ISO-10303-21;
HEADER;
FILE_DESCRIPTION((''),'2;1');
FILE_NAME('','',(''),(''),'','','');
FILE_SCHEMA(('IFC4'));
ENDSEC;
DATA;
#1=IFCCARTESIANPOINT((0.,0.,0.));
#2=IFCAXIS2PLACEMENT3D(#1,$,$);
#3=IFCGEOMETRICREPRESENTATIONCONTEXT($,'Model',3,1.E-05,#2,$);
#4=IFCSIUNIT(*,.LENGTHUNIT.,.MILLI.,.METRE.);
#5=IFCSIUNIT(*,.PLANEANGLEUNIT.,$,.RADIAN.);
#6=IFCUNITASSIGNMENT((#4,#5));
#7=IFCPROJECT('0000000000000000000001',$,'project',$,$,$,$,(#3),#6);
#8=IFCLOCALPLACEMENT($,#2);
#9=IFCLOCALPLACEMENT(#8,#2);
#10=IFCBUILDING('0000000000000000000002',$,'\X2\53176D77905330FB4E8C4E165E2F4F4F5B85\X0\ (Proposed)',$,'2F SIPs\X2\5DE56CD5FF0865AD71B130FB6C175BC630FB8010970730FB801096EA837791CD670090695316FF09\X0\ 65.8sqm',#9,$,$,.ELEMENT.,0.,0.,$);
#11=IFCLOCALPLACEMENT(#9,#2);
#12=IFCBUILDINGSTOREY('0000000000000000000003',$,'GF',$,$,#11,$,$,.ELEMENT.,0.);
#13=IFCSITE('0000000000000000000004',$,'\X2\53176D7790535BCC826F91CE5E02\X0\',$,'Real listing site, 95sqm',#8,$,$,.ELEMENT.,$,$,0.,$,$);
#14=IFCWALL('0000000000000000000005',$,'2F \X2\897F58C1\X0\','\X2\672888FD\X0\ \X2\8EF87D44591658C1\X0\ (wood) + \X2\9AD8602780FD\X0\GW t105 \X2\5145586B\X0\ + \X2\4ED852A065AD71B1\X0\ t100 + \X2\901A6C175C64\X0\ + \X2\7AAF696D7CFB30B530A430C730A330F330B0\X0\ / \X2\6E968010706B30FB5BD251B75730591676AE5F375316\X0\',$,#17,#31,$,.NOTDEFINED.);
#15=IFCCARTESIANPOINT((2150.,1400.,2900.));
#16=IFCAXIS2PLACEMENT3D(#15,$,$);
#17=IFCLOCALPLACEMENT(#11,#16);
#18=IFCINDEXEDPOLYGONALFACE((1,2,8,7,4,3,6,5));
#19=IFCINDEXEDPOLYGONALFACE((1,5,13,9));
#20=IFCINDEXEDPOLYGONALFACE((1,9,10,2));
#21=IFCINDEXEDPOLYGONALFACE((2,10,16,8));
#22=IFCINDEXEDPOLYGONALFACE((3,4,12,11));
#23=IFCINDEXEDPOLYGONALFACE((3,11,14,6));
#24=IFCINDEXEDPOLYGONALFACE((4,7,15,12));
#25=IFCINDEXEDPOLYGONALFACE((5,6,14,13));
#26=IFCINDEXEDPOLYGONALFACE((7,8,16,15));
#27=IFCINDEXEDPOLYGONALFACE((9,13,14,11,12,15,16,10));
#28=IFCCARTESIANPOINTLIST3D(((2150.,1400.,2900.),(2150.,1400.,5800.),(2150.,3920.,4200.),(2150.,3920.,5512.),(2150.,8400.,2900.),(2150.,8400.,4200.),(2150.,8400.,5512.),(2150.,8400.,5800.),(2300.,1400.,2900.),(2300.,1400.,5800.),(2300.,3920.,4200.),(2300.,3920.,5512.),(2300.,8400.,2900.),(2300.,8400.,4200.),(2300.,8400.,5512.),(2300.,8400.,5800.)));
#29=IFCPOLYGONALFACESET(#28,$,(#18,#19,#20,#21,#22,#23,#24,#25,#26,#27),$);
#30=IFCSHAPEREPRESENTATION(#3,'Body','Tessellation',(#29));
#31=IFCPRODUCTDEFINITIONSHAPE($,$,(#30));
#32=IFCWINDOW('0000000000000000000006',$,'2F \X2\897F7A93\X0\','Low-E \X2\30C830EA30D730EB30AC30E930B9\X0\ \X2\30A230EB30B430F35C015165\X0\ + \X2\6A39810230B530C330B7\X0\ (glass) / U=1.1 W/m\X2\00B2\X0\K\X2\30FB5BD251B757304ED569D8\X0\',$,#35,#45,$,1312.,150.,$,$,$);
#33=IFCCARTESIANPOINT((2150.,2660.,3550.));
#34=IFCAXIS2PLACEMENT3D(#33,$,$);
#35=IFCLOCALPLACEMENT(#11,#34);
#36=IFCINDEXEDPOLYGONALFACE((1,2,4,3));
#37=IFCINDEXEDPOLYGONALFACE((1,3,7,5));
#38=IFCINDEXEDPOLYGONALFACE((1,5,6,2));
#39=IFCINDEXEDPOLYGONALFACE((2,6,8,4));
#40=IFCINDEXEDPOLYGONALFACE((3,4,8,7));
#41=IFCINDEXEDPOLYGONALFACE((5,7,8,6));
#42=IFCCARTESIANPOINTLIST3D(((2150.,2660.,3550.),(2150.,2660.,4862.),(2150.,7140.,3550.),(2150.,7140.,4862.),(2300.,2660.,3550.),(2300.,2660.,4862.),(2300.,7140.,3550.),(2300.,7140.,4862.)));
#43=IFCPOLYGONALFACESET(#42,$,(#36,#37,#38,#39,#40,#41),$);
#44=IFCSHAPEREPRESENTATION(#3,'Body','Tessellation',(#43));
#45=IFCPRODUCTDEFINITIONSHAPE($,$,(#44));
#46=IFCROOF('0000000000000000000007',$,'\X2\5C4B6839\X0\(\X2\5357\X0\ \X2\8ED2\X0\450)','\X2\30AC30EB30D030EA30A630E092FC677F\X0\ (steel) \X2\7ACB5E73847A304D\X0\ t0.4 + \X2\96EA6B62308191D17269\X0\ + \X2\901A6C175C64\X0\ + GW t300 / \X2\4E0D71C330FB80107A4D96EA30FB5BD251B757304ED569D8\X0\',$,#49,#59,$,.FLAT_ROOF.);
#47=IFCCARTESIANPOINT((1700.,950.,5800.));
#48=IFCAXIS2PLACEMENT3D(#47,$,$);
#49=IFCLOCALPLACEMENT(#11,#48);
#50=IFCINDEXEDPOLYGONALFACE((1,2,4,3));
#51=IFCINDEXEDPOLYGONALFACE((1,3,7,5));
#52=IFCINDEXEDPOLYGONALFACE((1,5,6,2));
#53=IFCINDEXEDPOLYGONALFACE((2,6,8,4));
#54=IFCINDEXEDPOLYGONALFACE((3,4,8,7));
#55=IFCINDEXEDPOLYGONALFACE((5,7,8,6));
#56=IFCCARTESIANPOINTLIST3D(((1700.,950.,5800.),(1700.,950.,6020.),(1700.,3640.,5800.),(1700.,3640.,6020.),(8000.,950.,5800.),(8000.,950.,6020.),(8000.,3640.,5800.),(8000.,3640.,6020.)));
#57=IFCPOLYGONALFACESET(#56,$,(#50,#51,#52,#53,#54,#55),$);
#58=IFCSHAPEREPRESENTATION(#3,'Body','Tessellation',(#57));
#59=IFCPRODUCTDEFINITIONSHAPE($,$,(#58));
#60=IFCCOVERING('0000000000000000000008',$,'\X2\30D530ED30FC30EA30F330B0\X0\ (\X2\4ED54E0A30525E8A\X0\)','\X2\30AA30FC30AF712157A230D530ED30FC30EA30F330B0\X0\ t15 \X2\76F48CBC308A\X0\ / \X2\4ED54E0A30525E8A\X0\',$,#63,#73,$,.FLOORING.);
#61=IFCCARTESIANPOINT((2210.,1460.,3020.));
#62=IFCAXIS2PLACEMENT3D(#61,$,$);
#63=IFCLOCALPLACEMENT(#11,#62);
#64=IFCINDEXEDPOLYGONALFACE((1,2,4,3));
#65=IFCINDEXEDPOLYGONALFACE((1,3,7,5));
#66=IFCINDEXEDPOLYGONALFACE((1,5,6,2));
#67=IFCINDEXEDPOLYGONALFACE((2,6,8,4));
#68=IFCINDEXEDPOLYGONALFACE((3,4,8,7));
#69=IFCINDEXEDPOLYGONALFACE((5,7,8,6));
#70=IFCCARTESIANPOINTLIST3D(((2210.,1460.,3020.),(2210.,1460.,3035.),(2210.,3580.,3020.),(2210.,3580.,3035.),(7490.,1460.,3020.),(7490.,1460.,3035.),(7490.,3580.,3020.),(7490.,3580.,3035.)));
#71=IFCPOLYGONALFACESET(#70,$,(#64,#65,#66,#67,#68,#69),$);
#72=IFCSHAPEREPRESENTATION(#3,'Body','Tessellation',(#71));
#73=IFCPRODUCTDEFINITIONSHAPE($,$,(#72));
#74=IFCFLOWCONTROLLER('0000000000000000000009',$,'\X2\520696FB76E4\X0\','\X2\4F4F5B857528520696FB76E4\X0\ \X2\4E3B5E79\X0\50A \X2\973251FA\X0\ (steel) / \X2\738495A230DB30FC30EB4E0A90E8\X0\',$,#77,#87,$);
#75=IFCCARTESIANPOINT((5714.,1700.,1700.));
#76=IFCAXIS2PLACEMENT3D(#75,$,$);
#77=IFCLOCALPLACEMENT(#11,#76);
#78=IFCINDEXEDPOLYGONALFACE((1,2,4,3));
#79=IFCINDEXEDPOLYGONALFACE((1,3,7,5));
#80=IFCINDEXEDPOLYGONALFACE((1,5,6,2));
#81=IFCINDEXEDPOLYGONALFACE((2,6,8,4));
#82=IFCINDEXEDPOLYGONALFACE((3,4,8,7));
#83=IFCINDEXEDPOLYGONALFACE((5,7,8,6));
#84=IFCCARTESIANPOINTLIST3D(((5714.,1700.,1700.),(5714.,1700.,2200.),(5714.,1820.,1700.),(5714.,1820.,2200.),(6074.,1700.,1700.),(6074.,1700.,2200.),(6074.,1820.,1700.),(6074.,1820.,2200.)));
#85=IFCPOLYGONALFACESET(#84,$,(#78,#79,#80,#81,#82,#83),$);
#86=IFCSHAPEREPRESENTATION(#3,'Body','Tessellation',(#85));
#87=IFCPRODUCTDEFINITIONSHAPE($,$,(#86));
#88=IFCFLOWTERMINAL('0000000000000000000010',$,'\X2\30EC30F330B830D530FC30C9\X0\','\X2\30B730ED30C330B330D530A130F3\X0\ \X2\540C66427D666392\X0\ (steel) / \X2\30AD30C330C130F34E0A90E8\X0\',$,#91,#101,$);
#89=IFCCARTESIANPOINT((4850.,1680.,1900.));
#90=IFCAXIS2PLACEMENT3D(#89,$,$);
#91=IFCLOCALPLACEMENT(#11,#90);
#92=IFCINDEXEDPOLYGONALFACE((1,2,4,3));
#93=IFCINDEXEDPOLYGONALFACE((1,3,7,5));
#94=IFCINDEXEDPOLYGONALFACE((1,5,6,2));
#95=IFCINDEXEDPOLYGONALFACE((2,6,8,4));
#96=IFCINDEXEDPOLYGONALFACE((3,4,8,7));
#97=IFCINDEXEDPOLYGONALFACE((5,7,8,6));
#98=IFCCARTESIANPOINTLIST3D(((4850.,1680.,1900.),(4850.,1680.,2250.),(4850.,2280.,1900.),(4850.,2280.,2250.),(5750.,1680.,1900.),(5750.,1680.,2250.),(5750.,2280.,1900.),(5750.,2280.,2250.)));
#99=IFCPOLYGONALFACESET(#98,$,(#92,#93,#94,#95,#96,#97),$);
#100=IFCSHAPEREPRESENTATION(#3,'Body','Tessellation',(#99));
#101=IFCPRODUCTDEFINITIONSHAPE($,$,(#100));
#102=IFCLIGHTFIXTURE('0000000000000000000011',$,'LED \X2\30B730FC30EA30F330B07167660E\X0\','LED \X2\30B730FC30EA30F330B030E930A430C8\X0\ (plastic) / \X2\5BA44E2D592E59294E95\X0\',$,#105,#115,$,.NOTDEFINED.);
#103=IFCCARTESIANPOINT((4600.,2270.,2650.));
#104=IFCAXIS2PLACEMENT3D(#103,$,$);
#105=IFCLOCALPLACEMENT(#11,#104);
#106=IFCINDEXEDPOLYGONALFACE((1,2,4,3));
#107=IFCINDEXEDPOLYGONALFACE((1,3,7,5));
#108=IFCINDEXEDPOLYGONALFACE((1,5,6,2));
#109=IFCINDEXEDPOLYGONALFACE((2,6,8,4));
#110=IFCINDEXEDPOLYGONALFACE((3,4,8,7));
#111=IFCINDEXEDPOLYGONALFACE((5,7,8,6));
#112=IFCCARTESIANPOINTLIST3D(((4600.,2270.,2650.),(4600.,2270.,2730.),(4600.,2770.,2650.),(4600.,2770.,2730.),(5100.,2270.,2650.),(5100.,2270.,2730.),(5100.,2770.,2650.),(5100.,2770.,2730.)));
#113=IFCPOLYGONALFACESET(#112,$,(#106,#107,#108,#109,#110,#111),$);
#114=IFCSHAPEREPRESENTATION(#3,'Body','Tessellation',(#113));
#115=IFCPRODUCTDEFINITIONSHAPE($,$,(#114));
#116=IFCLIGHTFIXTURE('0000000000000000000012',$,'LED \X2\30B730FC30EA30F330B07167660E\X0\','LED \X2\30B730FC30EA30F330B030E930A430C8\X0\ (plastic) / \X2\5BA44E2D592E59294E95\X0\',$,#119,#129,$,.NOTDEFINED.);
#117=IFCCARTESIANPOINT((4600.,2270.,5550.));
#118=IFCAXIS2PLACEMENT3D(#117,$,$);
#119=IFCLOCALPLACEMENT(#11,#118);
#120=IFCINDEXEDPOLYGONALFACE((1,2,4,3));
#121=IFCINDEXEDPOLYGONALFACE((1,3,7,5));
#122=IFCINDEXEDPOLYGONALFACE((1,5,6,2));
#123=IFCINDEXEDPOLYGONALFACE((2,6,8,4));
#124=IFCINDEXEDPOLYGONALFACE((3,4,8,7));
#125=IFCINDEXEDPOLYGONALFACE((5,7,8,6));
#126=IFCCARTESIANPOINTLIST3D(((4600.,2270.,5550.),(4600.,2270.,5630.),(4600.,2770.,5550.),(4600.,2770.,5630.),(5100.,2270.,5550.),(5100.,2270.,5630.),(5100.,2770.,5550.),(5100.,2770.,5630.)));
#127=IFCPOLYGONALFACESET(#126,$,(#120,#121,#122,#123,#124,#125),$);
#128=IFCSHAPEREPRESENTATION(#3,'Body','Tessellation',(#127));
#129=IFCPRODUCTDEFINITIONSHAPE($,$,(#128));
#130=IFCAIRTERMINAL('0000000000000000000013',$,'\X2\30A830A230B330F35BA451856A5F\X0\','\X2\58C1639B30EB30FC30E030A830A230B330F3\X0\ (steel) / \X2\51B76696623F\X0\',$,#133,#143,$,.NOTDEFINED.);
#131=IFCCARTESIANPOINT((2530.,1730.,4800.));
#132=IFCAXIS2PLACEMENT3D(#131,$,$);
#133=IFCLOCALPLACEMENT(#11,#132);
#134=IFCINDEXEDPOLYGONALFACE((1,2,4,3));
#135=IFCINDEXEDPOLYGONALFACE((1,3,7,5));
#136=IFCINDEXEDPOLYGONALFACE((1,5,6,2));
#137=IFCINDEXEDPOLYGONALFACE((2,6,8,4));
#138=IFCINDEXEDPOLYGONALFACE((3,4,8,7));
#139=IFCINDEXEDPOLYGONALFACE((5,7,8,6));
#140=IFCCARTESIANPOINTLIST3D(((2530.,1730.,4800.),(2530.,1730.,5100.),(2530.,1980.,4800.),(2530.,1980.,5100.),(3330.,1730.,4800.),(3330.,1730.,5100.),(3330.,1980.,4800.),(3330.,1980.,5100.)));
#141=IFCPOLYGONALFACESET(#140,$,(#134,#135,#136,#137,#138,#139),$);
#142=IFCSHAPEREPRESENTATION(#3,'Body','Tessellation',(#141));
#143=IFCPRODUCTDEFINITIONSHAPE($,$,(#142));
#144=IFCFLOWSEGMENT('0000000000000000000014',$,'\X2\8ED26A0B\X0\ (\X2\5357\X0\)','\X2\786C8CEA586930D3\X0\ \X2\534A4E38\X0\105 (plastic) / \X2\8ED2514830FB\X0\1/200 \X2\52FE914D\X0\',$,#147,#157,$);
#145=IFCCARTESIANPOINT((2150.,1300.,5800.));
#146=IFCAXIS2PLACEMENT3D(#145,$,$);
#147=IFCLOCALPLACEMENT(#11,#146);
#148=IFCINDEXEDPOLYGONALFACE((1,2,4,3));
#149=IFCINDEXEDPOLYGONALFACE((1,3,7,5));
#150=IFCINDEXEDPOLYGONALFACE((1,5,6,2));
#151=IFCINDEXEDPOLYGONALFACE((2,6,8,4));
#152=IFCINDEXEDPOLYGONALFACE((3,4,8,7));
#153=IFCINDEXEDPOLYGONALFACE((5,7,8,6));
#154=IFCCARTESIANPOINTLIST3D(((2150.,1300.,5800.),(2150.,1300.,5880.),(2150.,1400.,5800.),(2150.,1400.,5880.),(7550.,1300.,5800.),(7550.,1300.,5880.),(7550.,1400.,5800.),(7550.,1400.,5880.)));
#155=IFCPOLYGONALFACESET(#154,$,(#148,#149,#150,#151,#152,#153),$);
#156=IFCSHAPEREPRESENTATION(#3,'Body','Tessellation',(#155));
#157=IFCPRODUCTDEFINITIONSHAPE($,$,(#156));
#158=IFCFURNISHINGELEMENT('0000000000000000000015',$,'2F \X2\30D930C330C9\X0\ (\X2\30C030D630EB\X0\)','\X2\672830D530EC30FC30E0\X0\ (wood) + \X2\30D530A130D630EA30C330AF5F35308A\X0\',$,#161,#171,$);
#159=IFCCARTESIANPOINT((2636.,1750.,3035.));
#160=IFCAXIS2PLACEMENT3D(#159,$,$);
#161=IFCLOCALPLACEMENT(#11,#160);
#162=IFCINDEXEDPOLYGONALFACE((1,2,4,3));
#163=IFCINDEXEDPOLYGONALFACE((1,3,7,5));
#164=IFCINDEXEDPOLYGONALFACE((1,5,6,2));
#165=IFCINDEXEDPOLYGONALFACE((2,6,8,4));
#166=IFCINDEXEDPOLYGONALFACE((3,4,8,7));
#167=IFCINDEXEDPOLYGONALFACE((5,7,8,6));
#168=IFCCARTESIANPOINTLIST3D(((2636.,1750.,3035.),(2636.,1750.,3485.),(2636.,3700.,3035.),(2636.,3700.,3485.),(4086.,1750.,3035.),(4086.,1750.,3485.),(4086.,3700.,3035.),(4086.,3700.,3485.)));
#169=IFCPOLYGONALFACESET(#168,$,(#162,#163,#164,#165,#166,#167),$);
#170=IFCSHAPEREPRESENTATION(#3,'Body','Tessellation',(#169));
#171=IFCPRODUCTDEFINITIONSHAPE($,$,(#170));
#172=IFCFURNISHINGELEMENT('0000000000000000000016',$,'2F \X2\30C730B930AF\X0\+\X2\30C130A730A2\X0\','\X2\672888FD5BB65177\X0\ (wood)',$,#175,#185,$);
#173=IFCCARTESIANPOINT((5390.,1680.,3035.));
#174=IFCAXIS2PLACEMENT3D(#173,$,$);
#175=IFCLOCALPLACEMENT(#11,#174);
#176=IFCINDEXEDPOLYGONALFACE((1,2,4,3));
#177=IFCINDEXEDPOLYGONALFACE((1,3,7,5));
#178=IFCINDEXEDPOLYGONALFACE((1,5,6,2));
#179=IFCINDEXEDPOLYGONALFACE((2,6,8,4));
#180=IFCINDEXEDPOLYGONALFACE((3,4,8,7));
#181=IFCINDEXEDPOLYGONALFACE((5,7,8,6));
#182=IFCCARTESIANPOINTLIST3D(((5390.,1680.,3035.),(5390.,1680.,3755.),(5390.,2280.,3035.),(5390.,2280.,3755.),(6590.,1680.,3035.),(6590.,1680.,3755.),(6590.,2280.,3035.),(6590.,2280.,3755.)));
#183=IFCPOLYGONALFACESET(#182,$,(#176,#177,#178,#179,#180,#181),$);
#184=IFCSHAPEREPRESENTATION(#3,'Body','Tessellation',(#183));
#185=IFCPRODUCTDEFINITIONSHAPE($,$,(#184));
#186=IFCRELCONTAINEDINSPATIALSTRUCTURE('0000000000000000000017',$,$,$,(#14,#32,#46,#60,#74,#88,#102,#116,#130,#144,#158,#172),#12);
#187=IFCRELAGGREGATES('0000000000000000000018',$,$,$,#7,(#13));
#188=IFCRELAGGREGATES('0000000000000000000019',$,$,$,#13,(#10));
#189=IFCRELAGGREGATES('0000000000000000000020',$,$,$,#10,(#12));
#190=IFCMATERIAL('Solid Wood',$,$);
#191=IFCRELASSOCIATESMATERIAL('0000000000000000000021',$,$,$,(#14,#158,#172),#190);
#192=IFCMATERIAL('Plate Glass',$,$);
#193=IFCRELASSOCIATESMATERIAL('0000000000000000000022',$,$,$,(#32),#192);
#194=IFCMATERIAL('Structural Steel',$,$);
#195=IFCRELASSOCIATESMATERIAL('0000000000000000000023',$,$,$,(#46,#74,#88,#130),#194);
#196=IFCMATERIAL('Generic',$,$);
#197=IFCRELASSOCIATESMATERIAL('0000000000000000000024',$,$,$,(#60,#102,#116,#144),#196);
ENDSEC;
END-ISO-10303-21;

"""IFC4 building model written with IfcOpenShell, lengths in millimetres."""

from ifc_helpers import new_model, si_unit, frame, frame_2d, origin, place, context, project, spatial, rectangle, extrude, material, element, fill, save


model = new_model("IFC4")

# Units and contexts
model_context = context("Model", 3, precision=1e-05, world=origin())
ifc_project = project(units=[si_unit("LENGTHUNIT", "METRE", prefix="MILLI"), si_unit("PLANEANGLEUNIT", "RADIAN")], contexts=[model_context])

# Site, building, storey
site_placement = place(None, origin())
site = spatial("IfcSite", under=ifc_project, at=site_placement, Name="北海道富良野市", ObjectType="Real listing site, 95sqm", CompositionType="ELEMENT", RefElevation=0.0)
building_placement = place(site_placement, origin())
building = spatial("IfcBuilding", under=site, at=building_placement, Name="北海道・二世帯住宅 (Proposed)", ObjectType="2F SIPs工法（断熱・気密・耐震・耐雪荷重最適化） 65.8sqm", CompositionType="ELEMENT", ElevationOfRefHeight=0.0, ElevationOfTerrain=0.0)
storey_placement = place(building_placement, origin())
storey = spatial("IfcBuildingStorey", under=building, at=storey_placement, Name="GF", CompositionType="ELEMENT", Elevation=0.0)

# Shared definitions
ifc_material_1 = material(Name="Solid Wood")

# Wall, opening, window
ifc_material_2 = material(Name="Plate Glass")
wall_1_placement = place(storey_placement, frame((2150.0, 1400.0, 2900.0)))
wall_1 = element("IfcWall", 1, at=wall_1_placement, inside=storey, material=ifc_material_1, Name="2F 西壁", Description="木製 軸組外壁 (wood) + 高性能GW t105 充填 + 付加断熱 t100 + 通気層 + 窯業系サイディング / 準耐火・寒冷地外皮強化", PredefinedType="NOTDEFINED", context=model_context, shape_type="SweptSolid", body=[
    extrude(rectangle(XDim=150.0, YDim=7000.0, at=frame_2d((75.0, 3500.0))), frame((2150.0, 1400.0, 2900.0)), (0.0, 0.0, 1.0), 2900.0),
])
opening_1_placement = place(storey_placement, frame((2150.0, 2660.0, 3550.0)))
opening_1 = element("IfcOpeningElement", 2, at=opening_1_placement, cuts=wall_1, PredefinedType="NOTDEFINED", context=model_context, shape_type="SweptSolid", body=[
    extrude(rectangle(XDim=150.0, YDim=4480.0, at=frame_2d((75.0, 2240.0))), frame((2150.0, 2660.0, 3550.0)), (0.0, 0.0, 1.0), 1312.0),
])
window_1_placement = place(storey_placement, frame((2150.0, 2660.0, 3550.0)))
window_1 = element("IfcWindow", 3, at=window_1_placement, inside=storey, material=ifc_material_2, Name="2F 西窓", Description="Low-E トリプルガラス アルゴン封入 + 樹脂サッシ (glass) / U=1.1 W/m²K・寒冷地仕様", OverallHeight=1312.0, OverallWidth=150.0, context=model_context, shape_type="SweptSolid", body=[
    extrude(rectangle(XDim=150.0, YDim=4480.0, at=frame_2d((75.0, 2240.0))), frame((2150.0, 2660.0, 3550.0)), (0.0, 0.0, 1.0), 1312.0),
])
fill(opening_1, window_1)

# Roof
ifc_material_3 = material(Name="Structural Steel")
for number, where, name in (
    (4, (1700.0, 950.0, 5800.0), "屋根(南 軒450)"),
):
    element("IfcRoof", number, at=place(storey_placement, frame(where)), inside=storey, material=ifc_material_3, Name=name, Description="ガルバリウム鋼板 (steel) 立平葺き t0.4 + 雪止め金物 + 通気層 + GW t300 / 不燃・耐積雪・寒冷地仕様", PredefinedType="FLAT_ROOF", context=model_context, shape_type="SweptSolid", body=[
        extrude(rectangle(XDim=6300.0, YDim=2690.0, at=frame_2d((3150.0, 1345.0))), frame((1700.0, 950.0, 5800.0)), (0.0, 0.0, 1.0), 220.0),
    ])

# Covering
ifc_material_4 = material(Name="Generic")
covering_placement = place(storey_placement, frame((2210.0, 1460.0, 3020.0)))
element("IfcCovering", 5, at=covering_placement, inside=storey, material=ifc_material_4, Name="フローリング (仕上げ床)", Description="オーク無垢フローリング t15 直貼り / 仕上げ床", PredefinedType="FLOORING", context=model_context, shape_type="SweptSolid", body=[
    extrude(rectangle(XDim=5280.0, YDim=2120.0, at=frame_2d((2640.0, 1060.0))), frame((2210.0, 1460.0, 3020.0)), (0.0, 0.0, 1.0), 15.0),
])

# Flow controller
flow_controller_placement = place(storey_placement, frame((5714.0, 1700.0, 1700.0)))
element("IfcFlowController", 6, at=flow_controller_placement, inside=storey, material=ifc_material_3, Name="分電盤", Description="住宅用分電盤 主幹50A 露出 (steel) / 玄関ホール上部", context=model_context, shape_type="SweptSolid", body=[
    extrude(rectangle(XDim=360.0, YDim=120.0, at=frame_2d((180.0, 60.0))), frame((5714.0, 1700.0, 1700.0)), (0.0, 0.0, 1.0), 500.0),
])

# Flow terminal
flow_terminal_placement = place(storey_placement, frame((4850.0, 1680.0, 1900.0)))
element("IfcFlowTerminal", 7, at=flow_terminal_placement, inside=storey, material=ifc_material_3, Name="レンジフード", Description="シロッコファン 同時給排 (steel) / キッチン上部", context=model_context, shape_type="SweptSolid", body=[
    extrude(rectangle(XDim=900.0, YDim=600.0, at=frame_2d((450.0, 300.0))), frame((4850.0, 1680.0, 1900.0)), (0.0, 0.0, 1.0), 350.0),
])

# Light fixtures
light_fixture_1_placement = place(storey_placement, frame((4600.0, 2270.0, 2650.0)))
element("IfcLightFixture", 8, at=light_fixture_1_placement, inside=storey, material=ifc_material_4, Name="LED シーリング照明", Description="LED シーリングライト (plastic) / 室中央天井", PredefinedType="NOTDEFINED", context=model_context, shape_type="SweptSolid", body=[
    extrude(rectangle(XDim=500.0, YDim=500.0, at=frame_2d((250.0, 250.0))), frame((4600.0, 2270.0, 2650.0)), (0.0, 0.0, 1.0), 80.0),
])
light_fixture_2_placement = place(storey_placement, frame((4600.0, 2270.0, 5550.0)))
element("IfcLightFixture", 9, at=light_fixture_2_placement, inside=storey, material=ifc_material_4, Name="LED シーリング照明", Description="LED シーリングライト (plastic) / 室中央天井", PredefinedType="NOTDEFINED", context=model_context, shape_type="SweptSolid", body=[
    extrude(rectangle(XDim=500.0, YDim=500.0, at=frame_2d((250.0, 250.0))), frame((4600.0, 2270.0, 5550.0)), (0.0, 0.0, 1.0), 80.0),
])

# Air terminal
air_terminal_placement = place(storey_placement, frame((2530.0, 1730.0, 4800.0)))
element("IfcAirTerminal", 10, at=air_terminal_placement, inside=storey, material=ifc_material_3, Name="エアコン室内機", Description="壁掛ルームエアコン (steel) / 冷暖房", PredefinedType="NOTDEFINED", context=model_context, shape_type="SweptSolid", body=[
    extrude(rectangle(XDim=800.0, YDim=250.0, at=frame_2d((400.0, 125.0))), frame((2530.0, 1730.0, 4800.0)), (0.0, 0.0, 1.0), 300.0),
])

# Flow segment
flow_segment_placement = place(storey_placement, frame((2150.0, 1300.0, 5800.0)))
element("IfcFlowSegment", 11, at=flow_segment_placement, inside=storey, material=ifc_material_4, Name="軒樋 (南)", Description="硬質塩ビ 半丸105 (plastic) / 軒先・1/200 勾配", context=model_context, shape_type="SweptSolid", body=[
    extrude(rectangle(XDim=5400.0, YDim=100.0, at=frame_2d((2700.0, 50.0))), frame((2150.0, 1300.0, 5800.0)), (0.0, 0.0, 1.0), 80.0),
])

# Furnishing elements
furnishing_1_placement = place(storey_placement, frame((2636.0, 1750.0, 3035.0)))
element("IfcFurnishingElement", 12, at=furnishing_1_placement, inside=storey, material=ifc_material_1, Name="2F ベッド (ダブル)", Description="木フレーム (wood) + ファブリック張り", context=model_context, shape_type="SweptSolid", body=[
    extrude(rectangle(XDim=1450.0, YDim=1950.0, at=frame_2d((725.0, 975.0))), frame((2636.0, 1750.0, 3035.0)), (0.0, 0.0, 1.0), 450.0),
])
furnishing_2_placement = place(storey_placement, frame((5390.0, 1680.0, 3035.0)))
element("IfcFurnishingElement", 13, at=furnishing_2_placement, inside=storey, material=ifc_material_1, Name="2F デスク+チェア", Description="木製家具 (wood)", context=model_context, shape_type="SweptSolid", body=[
    extrude(rectangle(XDim=1200.0, YDim=600.0, at=frame_2d((600.0, 300.0))), frame((5390.0, 1680.0, 3035.0)), (0.0, 0.0, 1.0), 720.0),
])

save(model, "model.ifc")
